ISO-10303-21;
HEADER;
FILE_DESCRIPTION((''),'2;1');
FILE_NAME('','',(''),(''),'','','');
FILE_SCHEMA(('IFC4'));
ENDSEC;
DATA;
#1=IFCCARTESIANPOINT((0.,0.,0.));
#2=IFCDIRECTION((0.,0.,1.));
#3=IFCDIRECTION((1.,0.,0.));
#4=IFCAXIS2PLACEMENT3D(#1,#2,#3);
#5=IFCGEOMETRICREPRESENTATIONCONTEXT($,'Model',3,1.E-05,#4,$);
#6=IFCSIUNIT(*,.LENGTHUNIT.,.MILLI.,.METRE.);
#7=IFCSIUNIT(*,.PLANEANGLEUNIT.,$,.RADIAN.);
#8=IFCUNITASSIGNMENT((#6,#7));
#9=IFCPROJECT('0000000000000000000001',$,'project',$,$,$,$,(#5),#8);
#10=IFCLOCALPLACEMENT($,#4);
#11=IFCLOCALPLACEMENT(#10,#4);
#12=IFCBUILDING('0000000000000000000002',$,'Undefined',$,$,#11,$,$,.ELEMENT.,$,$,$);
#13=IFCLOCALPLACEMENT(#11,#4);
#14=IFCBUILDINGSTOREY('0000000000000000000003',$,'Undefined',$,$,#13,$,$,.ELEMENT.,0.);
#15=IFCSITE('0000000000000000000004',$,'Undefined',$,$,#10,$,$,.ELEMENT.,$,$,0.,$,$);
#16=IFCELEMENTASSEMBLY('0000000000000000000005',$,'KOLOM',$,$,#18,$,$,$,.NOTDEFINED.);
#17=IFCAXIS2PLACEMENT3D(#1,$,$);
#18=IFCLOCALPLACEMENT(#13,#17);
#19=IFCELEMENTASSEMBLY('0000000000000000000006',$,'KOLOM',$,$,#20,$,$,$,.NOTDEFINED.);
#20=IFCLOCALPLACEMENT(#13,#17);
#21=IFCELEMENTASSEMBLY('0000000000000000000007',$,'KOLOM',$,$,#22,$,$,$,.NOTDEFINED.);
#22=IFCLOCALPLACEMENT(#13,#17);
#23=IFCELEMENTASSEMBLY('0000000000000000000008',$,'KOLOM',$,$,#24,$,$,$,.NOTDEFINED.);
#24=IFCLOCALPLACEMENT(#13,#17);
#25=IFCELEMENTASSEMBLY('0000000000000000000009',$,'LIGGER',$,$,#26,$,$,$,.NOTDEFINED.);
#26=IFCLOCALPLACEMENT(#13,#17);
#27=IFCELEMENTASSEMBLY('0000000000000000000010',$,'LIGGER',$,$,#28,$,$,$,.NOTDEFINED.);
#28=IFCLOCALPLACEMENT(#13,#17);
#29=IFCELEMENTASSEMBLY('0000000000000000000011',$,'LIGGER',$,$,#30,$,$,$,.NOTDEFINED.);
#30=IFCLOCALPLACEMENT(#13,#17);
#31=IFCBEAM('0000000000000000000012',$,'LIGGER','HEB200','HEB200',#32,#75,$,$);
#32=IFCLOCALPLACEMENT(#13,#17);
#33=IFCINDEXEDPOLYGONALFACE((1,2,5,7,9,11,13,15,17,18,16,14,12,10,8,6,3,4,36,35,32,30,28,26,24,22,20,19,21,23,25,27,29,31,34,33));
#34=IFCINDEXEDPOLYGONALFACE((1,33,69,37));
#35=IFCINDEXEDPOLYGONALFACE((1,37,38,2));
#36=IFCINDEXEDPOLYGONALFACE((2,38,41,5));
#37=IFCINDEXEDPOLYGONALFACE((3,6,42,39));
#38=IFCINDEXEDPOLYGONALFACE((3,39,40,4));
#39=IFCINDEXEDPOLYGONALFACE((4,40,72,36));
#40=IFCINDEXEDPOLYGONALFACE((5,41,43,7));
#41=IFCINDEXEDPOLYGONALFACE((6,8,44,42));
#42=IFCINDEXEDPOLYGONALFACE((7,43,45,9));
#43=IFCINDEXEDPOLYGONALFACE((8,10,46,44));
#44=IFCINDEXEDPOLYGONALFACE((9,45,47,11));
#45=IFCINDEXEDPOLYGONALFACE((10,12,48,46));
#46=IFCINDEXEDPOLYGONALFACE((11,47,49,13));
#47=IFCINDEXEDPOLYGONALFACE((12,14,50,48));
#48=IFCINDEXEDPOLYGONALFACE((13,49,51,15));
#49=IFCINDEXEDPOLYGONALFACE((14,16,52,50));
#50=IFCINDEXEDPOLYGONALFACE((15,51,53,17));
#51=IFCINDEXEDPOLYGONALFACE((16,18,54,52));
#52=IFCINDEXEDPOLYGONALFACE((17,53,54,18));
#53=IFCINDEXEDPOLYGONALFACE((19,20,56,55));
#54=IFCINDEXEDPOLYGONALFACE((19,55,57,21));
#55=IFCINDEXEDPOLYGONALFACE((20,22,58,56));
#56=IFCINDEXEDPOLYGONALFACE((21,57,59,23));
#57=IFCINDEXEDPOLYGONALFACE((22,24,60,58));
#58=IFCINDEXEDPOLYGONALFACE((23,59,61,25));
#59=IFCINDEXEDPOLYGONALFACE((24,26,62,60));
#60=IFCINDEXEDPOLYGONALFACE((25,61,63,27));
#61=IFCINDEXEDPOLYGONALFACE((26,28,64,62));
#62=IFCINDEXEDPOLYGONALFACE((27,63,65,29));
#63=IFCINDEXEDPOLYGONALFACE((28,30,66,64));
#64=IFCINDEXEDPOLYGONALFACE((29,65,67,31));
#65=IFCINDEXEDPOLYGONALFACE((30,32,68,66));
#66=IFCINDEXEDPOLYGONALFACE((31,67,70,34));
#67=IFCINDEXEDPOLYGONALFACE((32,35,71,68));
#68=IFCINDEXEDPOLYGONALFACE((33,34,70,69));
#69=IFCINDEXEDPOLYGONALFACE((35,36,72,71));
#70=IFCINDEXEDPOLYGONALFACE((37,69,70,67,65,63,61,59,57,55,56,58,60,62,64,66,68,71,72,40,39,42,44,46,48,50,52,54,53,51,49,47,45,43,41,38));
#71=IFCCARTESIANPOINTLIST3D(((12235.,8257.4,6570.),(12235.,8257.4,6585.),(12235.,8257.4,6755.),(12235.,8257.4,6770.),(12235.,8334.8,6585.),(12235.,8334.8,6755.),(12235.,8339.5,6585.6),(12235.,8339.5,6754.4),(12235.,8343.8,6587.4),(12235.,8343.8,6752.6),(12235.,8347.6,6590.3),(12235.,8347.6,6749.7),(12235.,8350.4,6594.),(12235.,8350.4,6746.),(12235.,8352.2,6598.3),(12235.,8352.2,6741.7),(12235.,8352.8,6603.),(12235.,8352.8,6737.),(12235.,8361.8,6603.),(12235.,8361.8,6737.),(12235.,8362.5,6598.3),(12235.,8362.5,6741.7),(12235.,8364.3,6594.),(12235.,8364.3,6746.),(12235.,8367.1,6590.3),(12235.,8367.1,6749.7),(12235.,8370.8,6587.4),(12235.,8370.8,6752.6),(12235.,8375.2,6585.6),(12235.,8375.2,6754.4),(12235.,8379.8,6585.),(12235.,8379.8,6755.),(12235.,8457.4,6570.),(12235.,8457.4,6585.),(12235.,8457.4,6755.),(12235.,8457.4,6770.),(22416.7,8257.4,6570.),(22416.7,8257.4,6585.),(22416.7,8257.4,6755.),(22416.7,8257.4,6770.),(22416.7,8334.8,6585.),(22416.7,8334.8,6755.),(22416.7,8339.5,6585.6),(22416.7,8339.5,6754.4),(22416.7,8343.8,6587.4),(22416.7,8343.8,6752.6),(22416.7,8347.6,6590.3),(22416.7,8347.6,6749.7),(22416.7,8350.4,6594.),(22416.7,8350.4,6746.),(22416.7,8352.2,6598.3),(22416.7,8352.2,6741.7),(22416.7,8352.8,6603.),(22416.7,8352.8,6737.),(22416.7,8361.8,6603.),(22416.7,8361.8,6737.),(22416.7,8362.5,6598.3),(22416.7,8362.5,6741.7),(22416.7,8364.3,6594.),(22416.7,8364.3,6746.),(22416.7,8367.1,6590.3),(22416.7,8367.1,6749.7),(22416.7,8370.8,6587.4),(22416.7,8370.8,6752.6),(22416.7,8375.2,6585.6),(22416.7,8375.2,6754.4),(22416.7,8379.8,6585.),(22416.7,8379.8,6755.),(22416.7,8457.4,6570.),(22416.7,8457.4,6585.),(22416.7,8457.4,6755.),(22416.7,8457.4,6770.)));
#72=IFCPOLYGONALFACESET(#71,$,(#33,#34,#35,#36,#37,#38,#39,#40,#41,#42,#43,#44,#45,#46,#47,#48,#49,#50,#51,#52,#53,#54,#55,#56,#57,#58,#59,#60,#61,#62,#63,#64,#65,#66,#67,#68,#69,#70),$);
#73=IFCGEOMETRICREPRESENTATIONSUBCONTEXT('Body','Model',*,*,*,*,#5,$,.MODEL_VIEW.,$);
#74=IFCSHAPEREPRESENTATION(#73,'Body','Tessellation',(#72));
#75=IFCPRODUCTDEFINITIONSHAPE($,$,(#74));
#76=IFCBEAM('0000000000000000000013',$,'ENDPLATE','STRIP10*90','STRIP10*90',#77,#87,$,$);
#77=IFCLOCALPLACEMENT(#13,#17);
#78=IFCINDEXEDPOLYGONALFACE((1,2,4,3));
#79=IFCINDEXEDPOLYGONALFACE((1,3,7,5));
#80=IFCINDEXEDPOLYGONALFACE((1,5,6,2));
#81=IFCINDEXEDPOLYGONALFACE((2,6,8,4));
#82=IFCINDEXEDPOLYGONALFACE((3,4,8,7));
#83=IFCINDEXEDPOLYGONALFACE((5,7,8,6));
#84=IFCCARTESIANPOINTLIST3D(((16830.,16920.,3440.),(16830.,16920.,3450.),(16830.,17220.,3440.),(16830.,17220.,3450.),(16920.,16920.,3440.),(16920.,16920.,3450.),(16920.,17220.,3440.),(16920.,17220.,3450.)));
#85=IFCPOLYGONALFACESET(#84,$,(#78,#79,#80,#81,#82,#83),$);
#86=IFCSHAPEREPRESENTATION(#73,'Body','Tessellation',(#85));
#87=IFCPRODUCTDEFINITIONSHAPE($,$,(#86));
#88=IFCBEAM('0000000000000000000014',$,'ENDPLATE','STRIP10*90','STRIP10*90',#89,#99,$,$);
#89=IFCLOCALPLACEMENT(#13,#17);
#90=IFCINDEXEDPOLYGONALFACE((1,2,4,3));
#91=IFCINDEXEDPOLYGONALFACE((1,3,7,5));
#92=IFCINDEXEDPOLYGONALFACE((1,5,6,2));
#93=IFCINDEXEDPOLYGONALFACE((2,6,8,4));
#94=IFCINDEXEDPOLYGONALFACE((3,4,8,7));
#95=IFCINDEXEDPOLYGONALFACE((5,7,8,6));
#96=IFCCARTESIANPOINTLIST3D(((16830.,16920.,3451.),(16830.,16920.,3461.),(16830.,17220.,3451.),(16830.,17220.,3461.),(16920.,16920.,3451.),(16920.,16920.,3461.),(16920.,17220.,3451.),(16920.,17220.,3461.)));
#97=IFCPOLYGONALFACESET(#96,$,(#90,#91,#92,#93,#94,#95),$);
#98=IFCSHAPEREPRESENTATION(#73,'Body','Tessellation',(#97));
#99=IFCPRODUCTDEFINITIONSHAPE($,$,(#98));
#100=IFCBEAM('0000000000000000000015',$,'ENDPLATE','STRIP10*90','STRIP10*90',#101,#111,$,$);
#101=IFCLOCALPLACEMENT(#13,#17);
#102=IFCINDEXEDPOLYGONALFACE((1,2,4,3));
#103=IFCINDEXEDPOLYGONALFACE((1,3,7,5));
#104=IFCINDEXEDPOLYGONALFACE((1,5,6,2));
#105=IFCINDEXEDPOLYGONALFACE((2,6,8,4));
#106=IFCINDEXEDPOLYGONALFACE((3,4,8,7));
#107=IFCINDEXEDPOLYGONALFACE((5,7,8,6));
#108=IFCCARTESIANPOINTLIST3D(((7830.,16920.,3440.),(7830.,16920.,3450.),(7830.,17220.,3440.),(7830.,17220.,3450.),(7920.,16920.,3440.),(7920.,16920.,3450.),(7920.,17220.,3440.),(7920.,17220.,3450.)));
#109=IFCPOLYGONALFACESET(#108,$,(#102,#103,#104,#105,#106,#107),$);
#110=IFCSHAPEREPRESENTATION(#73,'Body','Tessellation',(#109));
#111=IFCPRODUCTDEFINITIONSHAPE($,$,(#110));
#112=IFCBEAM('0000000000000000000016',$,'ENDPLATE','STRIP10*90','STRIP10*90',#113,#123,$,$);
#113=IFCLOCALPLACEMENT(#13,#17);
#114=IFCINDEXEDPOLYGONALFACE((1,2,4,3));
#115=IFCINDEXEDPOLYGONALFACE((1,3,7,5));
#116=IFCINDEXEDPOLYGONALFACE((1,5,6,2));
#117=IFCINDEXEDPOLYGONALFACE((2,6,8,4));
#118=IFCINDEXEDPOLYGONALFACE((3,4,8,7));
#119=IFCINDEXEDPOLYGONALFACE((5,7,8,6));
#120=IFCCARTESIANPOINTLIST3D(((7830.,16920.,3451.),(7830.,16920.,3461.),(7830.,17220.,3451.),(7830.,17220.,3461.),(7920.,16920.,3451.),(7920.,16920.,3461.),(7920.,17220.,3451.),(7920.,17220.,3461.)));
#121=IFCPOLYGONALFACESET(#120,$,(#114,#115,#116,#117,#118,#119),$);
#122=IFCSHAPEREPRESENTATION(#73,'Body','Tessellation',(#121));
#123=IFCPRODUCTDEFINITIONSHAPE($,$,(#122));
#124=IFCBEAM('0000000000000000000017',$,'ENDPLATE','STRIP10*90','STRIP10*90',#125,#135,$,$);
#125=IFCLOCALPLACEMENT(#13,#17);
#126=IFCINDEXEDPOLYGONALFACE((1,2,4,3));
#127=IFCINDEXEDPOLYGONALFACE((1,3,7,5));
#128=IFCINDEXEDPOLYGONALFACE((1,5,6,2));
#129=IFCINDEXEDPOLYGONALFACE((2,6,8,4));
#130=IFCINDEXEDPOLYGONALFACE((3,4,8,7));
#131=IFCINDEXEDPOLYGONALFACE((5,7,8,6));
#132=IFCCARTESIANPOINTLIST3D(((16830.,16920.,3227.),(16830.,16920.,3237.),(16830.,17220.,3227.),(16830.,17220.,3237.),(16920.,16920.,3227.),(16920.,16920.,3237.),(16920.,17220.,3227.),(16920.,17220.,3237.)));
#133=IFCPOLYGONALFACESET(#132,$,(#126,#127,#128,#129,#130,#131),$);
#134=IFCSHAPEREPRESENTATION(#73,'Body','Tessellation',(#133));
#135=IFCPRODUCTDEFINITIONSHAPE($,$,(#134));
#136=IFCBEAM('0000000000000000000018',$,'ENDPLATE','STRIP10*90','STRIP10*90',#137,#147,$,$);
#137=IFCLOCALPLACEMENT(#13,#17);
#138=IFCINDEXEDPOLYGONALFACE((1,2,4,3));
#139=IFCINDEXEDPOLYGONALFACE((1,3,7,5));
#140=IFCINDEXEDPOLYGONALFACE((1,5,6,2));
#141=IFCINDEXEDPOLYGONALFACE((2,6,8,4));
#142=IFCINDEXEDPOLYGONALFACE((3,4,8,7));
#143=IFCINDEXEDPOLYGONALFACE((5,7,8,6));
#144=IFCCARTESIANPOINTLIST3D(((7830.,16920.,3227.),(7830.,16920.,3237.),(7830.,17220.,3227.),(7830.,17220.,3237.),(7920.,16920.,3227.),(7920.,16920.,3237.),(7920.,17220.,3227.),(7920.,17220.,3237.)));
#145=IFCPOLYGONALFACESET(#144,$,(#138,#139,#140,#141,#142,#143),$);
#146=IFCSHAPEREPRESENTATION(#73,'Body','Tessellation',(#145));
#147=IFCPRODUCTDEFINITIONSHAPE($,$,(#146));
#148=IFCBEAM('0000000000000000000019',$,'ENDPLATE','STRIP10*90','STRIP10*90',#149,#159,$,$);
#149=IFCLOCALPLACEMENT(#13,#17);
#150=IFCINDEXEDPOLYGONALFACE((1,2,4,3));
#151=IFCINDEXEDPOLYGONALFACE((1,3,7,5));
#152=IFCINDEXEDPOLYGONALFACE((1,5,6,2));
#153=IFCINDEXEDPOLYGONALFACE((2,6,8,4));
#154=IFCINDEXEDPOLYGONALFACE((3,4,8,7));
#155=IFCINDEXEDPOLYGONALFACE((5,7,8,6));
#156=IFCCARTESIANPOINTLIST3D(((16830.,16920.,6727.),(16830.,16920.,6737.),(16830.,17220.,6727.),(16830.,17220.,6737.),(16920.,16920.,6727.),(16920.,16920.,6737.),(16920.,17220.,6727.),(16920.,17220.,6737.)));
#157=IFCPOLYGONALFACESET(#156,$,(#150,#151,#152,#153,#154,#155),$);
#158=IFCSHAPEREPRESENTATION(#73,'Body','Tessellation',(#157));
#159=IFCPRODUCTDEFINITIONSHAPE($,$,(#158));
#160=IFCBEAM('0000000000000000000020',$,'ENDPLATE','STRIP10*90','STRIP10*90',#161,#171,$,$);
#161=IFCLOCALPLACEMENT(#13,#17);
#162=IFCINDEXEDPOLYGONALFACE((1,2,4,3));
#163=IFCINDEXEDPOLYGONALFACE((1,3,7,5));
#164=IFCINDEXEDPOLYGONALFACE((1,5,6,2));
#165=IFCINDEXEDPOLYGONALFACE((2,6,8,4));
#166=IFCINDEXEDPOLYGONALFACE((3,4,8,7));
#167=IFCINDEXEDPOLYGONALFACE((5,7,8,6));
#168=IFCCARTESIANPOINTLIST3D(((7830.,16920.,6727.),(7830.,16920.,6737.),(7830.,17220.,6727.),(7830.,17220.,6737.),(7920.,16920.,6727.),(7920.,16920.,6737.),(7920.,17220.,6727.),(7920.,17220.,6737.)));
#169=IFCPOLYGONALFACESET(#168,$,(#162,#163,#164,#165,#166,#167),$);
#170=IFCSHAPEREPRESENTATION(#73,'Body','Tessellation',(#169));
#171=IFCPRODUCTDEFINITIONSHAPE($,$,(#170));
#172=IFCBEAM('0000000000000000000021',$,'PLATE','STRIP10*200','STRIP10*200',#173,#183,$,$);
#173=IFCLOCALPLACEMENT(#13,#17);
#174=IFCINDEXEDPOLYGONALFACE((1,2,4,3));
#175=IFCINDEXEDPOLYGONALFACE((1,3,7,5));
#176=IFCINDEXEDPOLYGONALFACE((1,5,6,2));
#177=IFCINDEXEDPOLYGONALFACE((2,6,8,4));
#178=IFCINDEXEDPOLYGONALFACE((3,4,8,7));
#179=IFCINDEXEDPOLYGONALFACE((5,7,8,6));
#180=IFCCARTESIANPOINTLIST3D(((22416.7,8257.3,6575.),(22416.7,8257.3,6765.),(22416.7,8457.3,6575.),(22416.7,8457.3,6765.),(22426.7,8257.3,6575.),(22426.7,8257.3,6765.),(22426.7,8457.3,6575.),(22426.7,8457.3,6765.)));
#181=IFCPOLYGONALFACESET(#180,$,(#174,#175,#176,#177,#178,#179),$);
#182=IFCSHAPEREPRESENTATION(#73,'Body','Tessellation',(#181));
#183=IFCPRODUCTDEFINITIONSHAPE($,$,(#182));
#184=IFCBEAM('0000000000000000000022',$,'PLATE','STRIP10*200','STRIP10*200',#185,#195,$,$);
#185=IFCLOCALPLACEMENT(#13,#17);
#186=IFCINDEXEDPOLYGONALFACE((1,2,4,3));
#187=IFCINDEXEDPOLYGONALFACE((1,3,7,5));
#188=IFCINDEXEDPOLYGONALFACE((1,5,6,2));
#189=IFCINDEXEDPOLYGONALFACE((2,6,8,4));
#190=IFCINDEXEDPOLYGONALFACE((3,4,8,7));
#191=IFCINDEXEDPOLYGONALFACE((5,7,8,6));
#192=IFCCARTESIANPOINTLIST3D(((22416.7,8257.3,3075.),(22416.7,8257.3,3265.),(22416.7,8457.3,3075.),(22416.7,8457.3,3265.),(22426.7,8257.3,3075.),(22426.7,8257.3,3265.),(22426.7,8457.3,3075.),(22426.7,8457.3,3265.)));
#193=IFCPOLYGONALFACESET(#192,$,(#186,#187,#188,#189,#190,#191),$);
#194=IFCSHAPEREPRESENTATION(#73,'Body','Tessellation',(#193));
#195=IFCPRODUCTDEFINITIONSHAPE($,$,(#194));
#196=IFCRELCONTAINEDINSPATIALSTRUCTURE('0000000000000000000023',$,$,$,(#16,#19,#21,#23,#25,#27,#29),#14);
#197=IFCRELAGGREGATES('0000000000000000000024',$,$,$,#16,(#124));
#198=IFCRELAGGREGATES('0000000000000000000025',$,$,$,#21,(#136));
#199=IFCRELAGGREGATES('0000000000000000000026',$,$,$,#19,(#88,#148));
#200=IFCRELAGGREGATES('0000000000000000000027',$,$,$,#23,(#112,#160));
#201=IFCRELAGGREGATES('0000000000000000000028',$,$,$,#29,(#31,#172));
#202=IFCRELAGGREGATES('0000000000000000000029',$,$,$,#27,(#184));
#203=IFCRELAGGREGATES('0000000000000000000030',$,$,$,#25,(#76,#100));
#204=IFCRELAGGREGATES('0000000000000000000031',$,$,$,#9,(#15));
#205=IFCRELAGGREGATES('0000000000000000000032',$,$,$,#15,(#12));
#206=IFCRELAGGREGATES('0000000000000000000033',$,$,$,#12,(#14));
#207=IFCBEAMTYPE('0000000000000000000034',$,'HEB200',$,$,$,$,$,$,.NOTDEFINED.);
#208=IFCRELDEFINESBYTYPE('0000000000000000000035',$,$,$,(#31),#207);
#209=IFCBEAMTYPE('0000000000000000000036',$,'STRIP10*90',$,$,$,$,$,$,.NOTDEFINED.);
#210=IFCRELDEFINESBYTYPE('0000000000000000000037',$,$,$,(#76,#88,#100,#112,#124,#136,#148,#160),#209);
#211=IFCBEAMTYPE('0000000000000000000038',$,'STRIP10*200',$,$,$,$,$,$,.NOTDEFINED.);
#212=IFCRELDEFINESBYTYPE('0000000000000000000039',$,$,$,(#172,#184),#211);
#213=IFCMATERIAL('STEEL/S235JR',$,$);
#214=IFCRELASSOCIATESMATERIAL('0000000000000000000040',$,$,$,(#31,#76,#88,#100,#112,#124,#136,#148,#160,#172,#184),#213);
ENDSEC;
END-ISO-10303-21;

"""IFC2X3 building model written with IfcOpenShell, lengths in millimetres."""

from ifc_helpers import new_model, si_unit, frame, origin_with_axes, origin_2d_with_axis, place, context, subcontext, project, spatial, rectangle, i_section, extrude, material, type_object, element, aggregate, save


model = new_model("IFC2X3")

# Units and contexts
model_context = context("Model", 3, precision=1e-05, world=origin_with_axes())
body_context = subcontext(model_context, "Body", "Model", "MODEL_VIEW")
ifc_project = project(units=[si_unit("LENGTHUNIT", "METRE", prefix="MILLI"), si_unit("PLANEANGLEUNIT", "RADIAN")], contexts=[model_context])

# Site, building, storey
site_placement = place(None, origin_with_axes())
site = spatial("IfcSite", under=ifc_project, at=site_placement, Name="Undefined", CompositionType="ELEMENT", RefElevation=0.0)
building_placement = place(site_placement, origin_with_axes())
building = spatial("IfcBuilding", under=site, at=building_placement, Name="Undefined", CompositionType="ELEMENT")
storey_placement = place(building_placement, origin_with_axes())
storey = spatial("IfcBuildingStorey", under=building, at=storey_placement, Name="Undefined", CompositionType="ELEMENT", Elevation=0.0)

# Element assemblies
assembly_1_placement = place(storey_placement, origin_with_axes())
assembly_1 = element("IfcElementAssembly", 1, at=assembly_1_placement, inside=storey, Name="KOLOM", PredefinedType="NOTDEFINED")
ifc_material = material(Name="STEEL/S235JR")
assembly_2_placement = place(storey_placement, origin_with_axes())
assembly_2 = element("IfcElementAssembly", 2, at=assembly_2_placement, inside=storey, Name="KOLOM", PredefinedType="NOTDEFINED")
assembly_3_placement = place(storey_placement, origin_with_axes())
assembly_3 = element("IfcElementAssembly", 3, at=assembly_3_placement, inside=storey, Name="KOLOM", PredefinedType="NOTDEFINED")
assembly_4_placement = place(storey_placement, origin_with_axes())
assembly_4 = element("IfcElementAssembly", 4, at=assembly_4_placement, inside=storey, Name="KOLOM", PredefinedType="NOTDEFINED")

# Element assemblies, beam
assembly_5_placement = place(storey_placement, origin_with_axes())
assembly_5 = element("IfcElementAssembly", 5, at=assembly_5_placement, inside=storey, Name="LIGGER", PredefinedType="NOTDEFINED")
assembly_6_placement = place(storey_placement, origin_with_axes())
assembly_6 = element("IfcElementAssembly", 6, at=assembly_6_placement, inside=storey, Name="LIGGER", PredefinedType="NOTDEFINED")
beam_type_1 = type_object("IfcBeamType", Name="HEB200", PredefinedType="NOTDEFINED")
assembly_7_placement = place(storey_placement, origin_with_axes())
assembly_7 = element("IfcElementAssembly", 7, at=assembly_7_placement, inside=storey, Name="LIGGER", PredefinedType="NOTDEFINED")
beam_1_placement = place(assembly_7_placement, frame((12235.0, 8357.4, 6670.0), z_axis=(0.0, 0.0, 1.0), x_axis=(1.0, 0.0, 0.0)))
beam_1 = element("IfcBeam", 8, at=beam_1_placement, type_object=beam_type_1, material=ifc_material, Name="LIGGER", Description="HEB200", ObjectType="HEB200", context=body_context, shape_type="SweptSolid", body=[
    extrude(i_section(OverallWidth=200.0, OverallDepth=200.0, WebThickness=9.0, FlangeThickness=15.0, FilletRadius=18.0, at=origin_2d_with_axis()), frame((10181.7, 0.0, 0.0), z_axis=(-1.0, 0.0, 0.0), x_axis=(0.0, -1.0, 0.0)), (0.0, 0.0, 1.0), 10181.7),
])

# Beams
beam_type_2 = type_object("IfcBeamType", Name="STRIP10*90", PredefinedType="NOTDEFINED")
beam_2_placement = place(assembly_5_placement, frame((16920.0, 17070.0, 3445.0), z_axis=(0.0, 1.0, 0.0), x_axis=(-1.0, 0.0, 0.0)))
beam_2 = element("IfcBeam", 9, at=beam_2_placement, type_object=beam_type_2, material=ifc_material, Name="ENDPLATE", Description="STRIP10*90", ObjectType="STRIP10*90", context=body_context, shape_type="SweptSolid", body=[
    extrude(rectangle(XDim=10.0, YDim=300.0, at=origin_2d_with_axis()), frame((90.0, 0.0, 0.0), z_axis=(-1.0, 0.0, 0.0), x_axis=(0.0, -1.0, 0.0)), (0.0, 0.0, 1.0), 90.0),
])
beam_3_placement = place(assembly_2_placement, frame((16920.0, 17070.0, 3456.0), z_axis=(0.0, -1.0, 0.0), x_axis=(-1.0, 0.0, 0.0)))
beam_3 = element("IfcBeam", 10, at=beam_3_placement, type_object=beam_type_2, material=ifc_material, Name="ENDPLATE", Description="STRIP10*90", ObjectType="STRIP10*90", context=body_context, shape_type="SweptSolid", body=[
    extrude(rectangle(XDim=10.0, YDim=300.0, at=origin_2d_with_axis()), frame((90.0, 0.0, 0.0), z_axis=(-1.0, 0.0, 0.0), x_axis=(0.0, -1.0, 0.0)), (0.0, 0.0, 1.0), 90.0),
])
beam_4_placement = place(assembly_5_placement, frame((7920.0, 17070.0, 3445.0), z_axis=(0.0, 1.0, 0.0), x_axis=(-1.0, 0.0, 0.0)))
beam_4 = element("IfcBeam", 11, at=beam_4_placement, type_object=beam_type_2, material=ifc_material, Name="ENDPLATE", Description="STRIP10*90", ObjectType="STRIP10*90", context=body_context, shape_type="SweptSolid", body=[
    extrude(rectangle(XDim=10.0, YDim=300.0, at=origin_2d_with_axis()), frame((90.0, 0.0, 0.0), z_axis=(-1.0, 0.0, 0.0), x_axis=(0.0, -1.0, 0.0)), (0.0, 0.0, 1.0), 90.0),
])
beam_5_placement = place(assembly_4_placement, frame((7920.0, 17070.0, 3456.0), z_axis=(0.0, -1.0, 0.0), x_axis=(-1.0, 0.0, 0.0)))
beam_5 = element("IfcBeam", 12, at=beam_5_placement, type_object=beam_type_2, material=ifc_material, Name="ENDPLATE", Description="STRIP10*90", ObjectType="STRIP10*90", context=body_context, shape_type="SweptSolid", body=[
    extrude(rectangle(XDim=10.0, YDim=300.0, at=origin_2d_with_axis()), frame((90.0, 0.0, 0.0), z_axis=(-1.0, 0.0, 0.0), x_axis=(0.0, -1.0, 0.0)), (0.0, 0.0, 1.0), 90.0),
])
beam_6_placement = place(assembly_1_placement, frame((16920.0, 17070.0, 3232.0), z_axis=(0.0, 1.0, 0.0), x_axis=(-1.0, 0.0, 0.0)))
beam_6 = element("IfcBeam", 13, at=beam_6_placement, type_object=beam_type_2, material=ifc_material, Name="ENDPLATE", Description="STRIP10*90", ObjectType="STRIP10*90", context=body_context, shape_type="SweptSolid", body=[
    extrude(rectangle(XDim=10.0, YDim=300.0, at=origin_2d_with_axis()), frame((90.0, 0.0, 0.0), z_axis=(-1.0, 0.0, 0.0), x_axis=(0.0, -1.0, 0.0)), (0.0, 0.0, 1.0), 90.0),
])
aggregate(assembly_1, [beam_6])
beam_7_placement = place(assembly_3_placement, frame((7920.0, 17070.0, 3232.0), z_axis=(0.0, 1.0, 0.0), x_axis=(-1.0, 0.0, 0.0)))
beam_7 = element("IfcBeam", 14, at=beam_7_placement, type_object=beam_type_2, material=ifc_material, Name="ENDPLATE", Description="STRIP10*90", ObjectType="STRIP10*90", context=body_context, shape_type="SweptSolid", body=[
    extrude(rectangle(XDim=10.0, YDim=300.0, at=origin_2d_with_axis()), frame((90.0, 0.0, 0.0), z_axis=(-1.0, 0.0, 0.0), x_axis=(0.0, -1.0, 0.0)), (0.0, 0.0, 1.0), 90.0),
])
aggregate(assembly_3, [beam_7])
beam_8_placement = place(assembly_2_placement, frame((16920.0, 17070.0, 6732.0), z_axis=(0.0, 1.0, 0.0), x_axis=(-1.0, 0.0, 0.0)))
beam_8 = element("IfcBeam", 15, at=beam_8_placement, type_object=beam_type_2, material=ifc_material, Name="ENDPLATE", Description="STRIP10*90", ObjectType="STRIP10*90", context=body_context, shape_type="SweptSolid", body=[
    extrude(rectangle(XDim=10.0, YDim=300.0, at=origin_2d_with_axis()), frame((90.0, 0.0, 0.0), z_axis=(-1.0, 0.0, 0.0), x_axis=(0.0, -1.0, 0.0)), (0.0, 0.0, 1.0), 90.0),
])
aggregate(assembly_2, [beam_3, beam_8])
beam_9_placement = place(assembly_4_placement, frame((7920.0, 17070.0, 6732.0), z_axis=(0.0, 1.0, 0.0), x_axis=(-1.0, 0.0, 0.0)))
beam_9 = element("IfcBeam", 16, at=beam_9_placement, type_object=beam_type_2, material=ifc_material, Name="ENDPLATE", Description="STRIP10*90", ObjectType="STRIP10*90", context=body_context, shape_type="SweptSolid", body=[
    extrude(rectangle(XDim=10.0, YDim=300.0, at=origin_2d_with_axis()), frame((90.0, 0.0, 0.0), z_axis=(-1.0, 0.0, 0.0), x_axis=(0.0, -1.0, 0.0)), (0.0, 0.0, 1.0), 90.0),
])
aggregate(assembly_4, [beam_5, beam_9])
beam_type_3 = type_object("IfcBeamType", Name="STRIP10*200", PredefinedType="NOTDEFINED")
beam_10_placement = place(assembly_7_placement, frame((22421.7, 8357.3, 6575.0), z_axis=(0.0, -1.0, 0.0), x_axis=(0.0, 0.0, 1.0)))
beam_10 = element("IfcBeam", 17, at=beam_10_placement, type_object=beam_type_3, material=ifc_material, Name="PLATE", Description="STRIP10*200", ObjectType="STRIP10*200", context=body_context, shape_type="SweptSolid", body=[
    extrude(rectangle(XDim=10.0, YDim=200.0, at=origin_2d_with_axis()), frame((190.0, 0.0, 0.0), z_axis=(-1.0, 0.0, 0.0), x_axis=(0.0, -1.0, 0.0)), (0.0, 0.0, 1.0), 190.0),
])
aggregate(assembly_7, [beam_1, beam_10])
beam_11_placement = place(assembly_6_placement, frame((22421.7, 8357.3, 3075.0), z_axis=(0.0, -1.0, 0.0), x_axis=(0.0, 0.0, 1.0)))
beam_11 = element("IfcBeam", 18, at=beam_11_placement, type_object=beam_type_3, material=ifc_material, Name="PLATE", Description="STRIP10*200", ObjectType="STRIP10*200", context=body_context, shape_type="SweptSolid", body=[
    extrude(rectangle(XDim=10.0, YDim=200.0, at=origin_2d_with_axis()), frame((190.0, 0.0, 0.0), z_axis=(-1.0, 0.0, 0.0), x_axis=(0.0, -1.0, 0.0)), (0.0, 0.0, 1.0), 190.0),
])
aggregate(assembly_6, [beam_11])
aggregate(assembly_5, [beam_2, beam_4])

save(model, "model.ifc")
